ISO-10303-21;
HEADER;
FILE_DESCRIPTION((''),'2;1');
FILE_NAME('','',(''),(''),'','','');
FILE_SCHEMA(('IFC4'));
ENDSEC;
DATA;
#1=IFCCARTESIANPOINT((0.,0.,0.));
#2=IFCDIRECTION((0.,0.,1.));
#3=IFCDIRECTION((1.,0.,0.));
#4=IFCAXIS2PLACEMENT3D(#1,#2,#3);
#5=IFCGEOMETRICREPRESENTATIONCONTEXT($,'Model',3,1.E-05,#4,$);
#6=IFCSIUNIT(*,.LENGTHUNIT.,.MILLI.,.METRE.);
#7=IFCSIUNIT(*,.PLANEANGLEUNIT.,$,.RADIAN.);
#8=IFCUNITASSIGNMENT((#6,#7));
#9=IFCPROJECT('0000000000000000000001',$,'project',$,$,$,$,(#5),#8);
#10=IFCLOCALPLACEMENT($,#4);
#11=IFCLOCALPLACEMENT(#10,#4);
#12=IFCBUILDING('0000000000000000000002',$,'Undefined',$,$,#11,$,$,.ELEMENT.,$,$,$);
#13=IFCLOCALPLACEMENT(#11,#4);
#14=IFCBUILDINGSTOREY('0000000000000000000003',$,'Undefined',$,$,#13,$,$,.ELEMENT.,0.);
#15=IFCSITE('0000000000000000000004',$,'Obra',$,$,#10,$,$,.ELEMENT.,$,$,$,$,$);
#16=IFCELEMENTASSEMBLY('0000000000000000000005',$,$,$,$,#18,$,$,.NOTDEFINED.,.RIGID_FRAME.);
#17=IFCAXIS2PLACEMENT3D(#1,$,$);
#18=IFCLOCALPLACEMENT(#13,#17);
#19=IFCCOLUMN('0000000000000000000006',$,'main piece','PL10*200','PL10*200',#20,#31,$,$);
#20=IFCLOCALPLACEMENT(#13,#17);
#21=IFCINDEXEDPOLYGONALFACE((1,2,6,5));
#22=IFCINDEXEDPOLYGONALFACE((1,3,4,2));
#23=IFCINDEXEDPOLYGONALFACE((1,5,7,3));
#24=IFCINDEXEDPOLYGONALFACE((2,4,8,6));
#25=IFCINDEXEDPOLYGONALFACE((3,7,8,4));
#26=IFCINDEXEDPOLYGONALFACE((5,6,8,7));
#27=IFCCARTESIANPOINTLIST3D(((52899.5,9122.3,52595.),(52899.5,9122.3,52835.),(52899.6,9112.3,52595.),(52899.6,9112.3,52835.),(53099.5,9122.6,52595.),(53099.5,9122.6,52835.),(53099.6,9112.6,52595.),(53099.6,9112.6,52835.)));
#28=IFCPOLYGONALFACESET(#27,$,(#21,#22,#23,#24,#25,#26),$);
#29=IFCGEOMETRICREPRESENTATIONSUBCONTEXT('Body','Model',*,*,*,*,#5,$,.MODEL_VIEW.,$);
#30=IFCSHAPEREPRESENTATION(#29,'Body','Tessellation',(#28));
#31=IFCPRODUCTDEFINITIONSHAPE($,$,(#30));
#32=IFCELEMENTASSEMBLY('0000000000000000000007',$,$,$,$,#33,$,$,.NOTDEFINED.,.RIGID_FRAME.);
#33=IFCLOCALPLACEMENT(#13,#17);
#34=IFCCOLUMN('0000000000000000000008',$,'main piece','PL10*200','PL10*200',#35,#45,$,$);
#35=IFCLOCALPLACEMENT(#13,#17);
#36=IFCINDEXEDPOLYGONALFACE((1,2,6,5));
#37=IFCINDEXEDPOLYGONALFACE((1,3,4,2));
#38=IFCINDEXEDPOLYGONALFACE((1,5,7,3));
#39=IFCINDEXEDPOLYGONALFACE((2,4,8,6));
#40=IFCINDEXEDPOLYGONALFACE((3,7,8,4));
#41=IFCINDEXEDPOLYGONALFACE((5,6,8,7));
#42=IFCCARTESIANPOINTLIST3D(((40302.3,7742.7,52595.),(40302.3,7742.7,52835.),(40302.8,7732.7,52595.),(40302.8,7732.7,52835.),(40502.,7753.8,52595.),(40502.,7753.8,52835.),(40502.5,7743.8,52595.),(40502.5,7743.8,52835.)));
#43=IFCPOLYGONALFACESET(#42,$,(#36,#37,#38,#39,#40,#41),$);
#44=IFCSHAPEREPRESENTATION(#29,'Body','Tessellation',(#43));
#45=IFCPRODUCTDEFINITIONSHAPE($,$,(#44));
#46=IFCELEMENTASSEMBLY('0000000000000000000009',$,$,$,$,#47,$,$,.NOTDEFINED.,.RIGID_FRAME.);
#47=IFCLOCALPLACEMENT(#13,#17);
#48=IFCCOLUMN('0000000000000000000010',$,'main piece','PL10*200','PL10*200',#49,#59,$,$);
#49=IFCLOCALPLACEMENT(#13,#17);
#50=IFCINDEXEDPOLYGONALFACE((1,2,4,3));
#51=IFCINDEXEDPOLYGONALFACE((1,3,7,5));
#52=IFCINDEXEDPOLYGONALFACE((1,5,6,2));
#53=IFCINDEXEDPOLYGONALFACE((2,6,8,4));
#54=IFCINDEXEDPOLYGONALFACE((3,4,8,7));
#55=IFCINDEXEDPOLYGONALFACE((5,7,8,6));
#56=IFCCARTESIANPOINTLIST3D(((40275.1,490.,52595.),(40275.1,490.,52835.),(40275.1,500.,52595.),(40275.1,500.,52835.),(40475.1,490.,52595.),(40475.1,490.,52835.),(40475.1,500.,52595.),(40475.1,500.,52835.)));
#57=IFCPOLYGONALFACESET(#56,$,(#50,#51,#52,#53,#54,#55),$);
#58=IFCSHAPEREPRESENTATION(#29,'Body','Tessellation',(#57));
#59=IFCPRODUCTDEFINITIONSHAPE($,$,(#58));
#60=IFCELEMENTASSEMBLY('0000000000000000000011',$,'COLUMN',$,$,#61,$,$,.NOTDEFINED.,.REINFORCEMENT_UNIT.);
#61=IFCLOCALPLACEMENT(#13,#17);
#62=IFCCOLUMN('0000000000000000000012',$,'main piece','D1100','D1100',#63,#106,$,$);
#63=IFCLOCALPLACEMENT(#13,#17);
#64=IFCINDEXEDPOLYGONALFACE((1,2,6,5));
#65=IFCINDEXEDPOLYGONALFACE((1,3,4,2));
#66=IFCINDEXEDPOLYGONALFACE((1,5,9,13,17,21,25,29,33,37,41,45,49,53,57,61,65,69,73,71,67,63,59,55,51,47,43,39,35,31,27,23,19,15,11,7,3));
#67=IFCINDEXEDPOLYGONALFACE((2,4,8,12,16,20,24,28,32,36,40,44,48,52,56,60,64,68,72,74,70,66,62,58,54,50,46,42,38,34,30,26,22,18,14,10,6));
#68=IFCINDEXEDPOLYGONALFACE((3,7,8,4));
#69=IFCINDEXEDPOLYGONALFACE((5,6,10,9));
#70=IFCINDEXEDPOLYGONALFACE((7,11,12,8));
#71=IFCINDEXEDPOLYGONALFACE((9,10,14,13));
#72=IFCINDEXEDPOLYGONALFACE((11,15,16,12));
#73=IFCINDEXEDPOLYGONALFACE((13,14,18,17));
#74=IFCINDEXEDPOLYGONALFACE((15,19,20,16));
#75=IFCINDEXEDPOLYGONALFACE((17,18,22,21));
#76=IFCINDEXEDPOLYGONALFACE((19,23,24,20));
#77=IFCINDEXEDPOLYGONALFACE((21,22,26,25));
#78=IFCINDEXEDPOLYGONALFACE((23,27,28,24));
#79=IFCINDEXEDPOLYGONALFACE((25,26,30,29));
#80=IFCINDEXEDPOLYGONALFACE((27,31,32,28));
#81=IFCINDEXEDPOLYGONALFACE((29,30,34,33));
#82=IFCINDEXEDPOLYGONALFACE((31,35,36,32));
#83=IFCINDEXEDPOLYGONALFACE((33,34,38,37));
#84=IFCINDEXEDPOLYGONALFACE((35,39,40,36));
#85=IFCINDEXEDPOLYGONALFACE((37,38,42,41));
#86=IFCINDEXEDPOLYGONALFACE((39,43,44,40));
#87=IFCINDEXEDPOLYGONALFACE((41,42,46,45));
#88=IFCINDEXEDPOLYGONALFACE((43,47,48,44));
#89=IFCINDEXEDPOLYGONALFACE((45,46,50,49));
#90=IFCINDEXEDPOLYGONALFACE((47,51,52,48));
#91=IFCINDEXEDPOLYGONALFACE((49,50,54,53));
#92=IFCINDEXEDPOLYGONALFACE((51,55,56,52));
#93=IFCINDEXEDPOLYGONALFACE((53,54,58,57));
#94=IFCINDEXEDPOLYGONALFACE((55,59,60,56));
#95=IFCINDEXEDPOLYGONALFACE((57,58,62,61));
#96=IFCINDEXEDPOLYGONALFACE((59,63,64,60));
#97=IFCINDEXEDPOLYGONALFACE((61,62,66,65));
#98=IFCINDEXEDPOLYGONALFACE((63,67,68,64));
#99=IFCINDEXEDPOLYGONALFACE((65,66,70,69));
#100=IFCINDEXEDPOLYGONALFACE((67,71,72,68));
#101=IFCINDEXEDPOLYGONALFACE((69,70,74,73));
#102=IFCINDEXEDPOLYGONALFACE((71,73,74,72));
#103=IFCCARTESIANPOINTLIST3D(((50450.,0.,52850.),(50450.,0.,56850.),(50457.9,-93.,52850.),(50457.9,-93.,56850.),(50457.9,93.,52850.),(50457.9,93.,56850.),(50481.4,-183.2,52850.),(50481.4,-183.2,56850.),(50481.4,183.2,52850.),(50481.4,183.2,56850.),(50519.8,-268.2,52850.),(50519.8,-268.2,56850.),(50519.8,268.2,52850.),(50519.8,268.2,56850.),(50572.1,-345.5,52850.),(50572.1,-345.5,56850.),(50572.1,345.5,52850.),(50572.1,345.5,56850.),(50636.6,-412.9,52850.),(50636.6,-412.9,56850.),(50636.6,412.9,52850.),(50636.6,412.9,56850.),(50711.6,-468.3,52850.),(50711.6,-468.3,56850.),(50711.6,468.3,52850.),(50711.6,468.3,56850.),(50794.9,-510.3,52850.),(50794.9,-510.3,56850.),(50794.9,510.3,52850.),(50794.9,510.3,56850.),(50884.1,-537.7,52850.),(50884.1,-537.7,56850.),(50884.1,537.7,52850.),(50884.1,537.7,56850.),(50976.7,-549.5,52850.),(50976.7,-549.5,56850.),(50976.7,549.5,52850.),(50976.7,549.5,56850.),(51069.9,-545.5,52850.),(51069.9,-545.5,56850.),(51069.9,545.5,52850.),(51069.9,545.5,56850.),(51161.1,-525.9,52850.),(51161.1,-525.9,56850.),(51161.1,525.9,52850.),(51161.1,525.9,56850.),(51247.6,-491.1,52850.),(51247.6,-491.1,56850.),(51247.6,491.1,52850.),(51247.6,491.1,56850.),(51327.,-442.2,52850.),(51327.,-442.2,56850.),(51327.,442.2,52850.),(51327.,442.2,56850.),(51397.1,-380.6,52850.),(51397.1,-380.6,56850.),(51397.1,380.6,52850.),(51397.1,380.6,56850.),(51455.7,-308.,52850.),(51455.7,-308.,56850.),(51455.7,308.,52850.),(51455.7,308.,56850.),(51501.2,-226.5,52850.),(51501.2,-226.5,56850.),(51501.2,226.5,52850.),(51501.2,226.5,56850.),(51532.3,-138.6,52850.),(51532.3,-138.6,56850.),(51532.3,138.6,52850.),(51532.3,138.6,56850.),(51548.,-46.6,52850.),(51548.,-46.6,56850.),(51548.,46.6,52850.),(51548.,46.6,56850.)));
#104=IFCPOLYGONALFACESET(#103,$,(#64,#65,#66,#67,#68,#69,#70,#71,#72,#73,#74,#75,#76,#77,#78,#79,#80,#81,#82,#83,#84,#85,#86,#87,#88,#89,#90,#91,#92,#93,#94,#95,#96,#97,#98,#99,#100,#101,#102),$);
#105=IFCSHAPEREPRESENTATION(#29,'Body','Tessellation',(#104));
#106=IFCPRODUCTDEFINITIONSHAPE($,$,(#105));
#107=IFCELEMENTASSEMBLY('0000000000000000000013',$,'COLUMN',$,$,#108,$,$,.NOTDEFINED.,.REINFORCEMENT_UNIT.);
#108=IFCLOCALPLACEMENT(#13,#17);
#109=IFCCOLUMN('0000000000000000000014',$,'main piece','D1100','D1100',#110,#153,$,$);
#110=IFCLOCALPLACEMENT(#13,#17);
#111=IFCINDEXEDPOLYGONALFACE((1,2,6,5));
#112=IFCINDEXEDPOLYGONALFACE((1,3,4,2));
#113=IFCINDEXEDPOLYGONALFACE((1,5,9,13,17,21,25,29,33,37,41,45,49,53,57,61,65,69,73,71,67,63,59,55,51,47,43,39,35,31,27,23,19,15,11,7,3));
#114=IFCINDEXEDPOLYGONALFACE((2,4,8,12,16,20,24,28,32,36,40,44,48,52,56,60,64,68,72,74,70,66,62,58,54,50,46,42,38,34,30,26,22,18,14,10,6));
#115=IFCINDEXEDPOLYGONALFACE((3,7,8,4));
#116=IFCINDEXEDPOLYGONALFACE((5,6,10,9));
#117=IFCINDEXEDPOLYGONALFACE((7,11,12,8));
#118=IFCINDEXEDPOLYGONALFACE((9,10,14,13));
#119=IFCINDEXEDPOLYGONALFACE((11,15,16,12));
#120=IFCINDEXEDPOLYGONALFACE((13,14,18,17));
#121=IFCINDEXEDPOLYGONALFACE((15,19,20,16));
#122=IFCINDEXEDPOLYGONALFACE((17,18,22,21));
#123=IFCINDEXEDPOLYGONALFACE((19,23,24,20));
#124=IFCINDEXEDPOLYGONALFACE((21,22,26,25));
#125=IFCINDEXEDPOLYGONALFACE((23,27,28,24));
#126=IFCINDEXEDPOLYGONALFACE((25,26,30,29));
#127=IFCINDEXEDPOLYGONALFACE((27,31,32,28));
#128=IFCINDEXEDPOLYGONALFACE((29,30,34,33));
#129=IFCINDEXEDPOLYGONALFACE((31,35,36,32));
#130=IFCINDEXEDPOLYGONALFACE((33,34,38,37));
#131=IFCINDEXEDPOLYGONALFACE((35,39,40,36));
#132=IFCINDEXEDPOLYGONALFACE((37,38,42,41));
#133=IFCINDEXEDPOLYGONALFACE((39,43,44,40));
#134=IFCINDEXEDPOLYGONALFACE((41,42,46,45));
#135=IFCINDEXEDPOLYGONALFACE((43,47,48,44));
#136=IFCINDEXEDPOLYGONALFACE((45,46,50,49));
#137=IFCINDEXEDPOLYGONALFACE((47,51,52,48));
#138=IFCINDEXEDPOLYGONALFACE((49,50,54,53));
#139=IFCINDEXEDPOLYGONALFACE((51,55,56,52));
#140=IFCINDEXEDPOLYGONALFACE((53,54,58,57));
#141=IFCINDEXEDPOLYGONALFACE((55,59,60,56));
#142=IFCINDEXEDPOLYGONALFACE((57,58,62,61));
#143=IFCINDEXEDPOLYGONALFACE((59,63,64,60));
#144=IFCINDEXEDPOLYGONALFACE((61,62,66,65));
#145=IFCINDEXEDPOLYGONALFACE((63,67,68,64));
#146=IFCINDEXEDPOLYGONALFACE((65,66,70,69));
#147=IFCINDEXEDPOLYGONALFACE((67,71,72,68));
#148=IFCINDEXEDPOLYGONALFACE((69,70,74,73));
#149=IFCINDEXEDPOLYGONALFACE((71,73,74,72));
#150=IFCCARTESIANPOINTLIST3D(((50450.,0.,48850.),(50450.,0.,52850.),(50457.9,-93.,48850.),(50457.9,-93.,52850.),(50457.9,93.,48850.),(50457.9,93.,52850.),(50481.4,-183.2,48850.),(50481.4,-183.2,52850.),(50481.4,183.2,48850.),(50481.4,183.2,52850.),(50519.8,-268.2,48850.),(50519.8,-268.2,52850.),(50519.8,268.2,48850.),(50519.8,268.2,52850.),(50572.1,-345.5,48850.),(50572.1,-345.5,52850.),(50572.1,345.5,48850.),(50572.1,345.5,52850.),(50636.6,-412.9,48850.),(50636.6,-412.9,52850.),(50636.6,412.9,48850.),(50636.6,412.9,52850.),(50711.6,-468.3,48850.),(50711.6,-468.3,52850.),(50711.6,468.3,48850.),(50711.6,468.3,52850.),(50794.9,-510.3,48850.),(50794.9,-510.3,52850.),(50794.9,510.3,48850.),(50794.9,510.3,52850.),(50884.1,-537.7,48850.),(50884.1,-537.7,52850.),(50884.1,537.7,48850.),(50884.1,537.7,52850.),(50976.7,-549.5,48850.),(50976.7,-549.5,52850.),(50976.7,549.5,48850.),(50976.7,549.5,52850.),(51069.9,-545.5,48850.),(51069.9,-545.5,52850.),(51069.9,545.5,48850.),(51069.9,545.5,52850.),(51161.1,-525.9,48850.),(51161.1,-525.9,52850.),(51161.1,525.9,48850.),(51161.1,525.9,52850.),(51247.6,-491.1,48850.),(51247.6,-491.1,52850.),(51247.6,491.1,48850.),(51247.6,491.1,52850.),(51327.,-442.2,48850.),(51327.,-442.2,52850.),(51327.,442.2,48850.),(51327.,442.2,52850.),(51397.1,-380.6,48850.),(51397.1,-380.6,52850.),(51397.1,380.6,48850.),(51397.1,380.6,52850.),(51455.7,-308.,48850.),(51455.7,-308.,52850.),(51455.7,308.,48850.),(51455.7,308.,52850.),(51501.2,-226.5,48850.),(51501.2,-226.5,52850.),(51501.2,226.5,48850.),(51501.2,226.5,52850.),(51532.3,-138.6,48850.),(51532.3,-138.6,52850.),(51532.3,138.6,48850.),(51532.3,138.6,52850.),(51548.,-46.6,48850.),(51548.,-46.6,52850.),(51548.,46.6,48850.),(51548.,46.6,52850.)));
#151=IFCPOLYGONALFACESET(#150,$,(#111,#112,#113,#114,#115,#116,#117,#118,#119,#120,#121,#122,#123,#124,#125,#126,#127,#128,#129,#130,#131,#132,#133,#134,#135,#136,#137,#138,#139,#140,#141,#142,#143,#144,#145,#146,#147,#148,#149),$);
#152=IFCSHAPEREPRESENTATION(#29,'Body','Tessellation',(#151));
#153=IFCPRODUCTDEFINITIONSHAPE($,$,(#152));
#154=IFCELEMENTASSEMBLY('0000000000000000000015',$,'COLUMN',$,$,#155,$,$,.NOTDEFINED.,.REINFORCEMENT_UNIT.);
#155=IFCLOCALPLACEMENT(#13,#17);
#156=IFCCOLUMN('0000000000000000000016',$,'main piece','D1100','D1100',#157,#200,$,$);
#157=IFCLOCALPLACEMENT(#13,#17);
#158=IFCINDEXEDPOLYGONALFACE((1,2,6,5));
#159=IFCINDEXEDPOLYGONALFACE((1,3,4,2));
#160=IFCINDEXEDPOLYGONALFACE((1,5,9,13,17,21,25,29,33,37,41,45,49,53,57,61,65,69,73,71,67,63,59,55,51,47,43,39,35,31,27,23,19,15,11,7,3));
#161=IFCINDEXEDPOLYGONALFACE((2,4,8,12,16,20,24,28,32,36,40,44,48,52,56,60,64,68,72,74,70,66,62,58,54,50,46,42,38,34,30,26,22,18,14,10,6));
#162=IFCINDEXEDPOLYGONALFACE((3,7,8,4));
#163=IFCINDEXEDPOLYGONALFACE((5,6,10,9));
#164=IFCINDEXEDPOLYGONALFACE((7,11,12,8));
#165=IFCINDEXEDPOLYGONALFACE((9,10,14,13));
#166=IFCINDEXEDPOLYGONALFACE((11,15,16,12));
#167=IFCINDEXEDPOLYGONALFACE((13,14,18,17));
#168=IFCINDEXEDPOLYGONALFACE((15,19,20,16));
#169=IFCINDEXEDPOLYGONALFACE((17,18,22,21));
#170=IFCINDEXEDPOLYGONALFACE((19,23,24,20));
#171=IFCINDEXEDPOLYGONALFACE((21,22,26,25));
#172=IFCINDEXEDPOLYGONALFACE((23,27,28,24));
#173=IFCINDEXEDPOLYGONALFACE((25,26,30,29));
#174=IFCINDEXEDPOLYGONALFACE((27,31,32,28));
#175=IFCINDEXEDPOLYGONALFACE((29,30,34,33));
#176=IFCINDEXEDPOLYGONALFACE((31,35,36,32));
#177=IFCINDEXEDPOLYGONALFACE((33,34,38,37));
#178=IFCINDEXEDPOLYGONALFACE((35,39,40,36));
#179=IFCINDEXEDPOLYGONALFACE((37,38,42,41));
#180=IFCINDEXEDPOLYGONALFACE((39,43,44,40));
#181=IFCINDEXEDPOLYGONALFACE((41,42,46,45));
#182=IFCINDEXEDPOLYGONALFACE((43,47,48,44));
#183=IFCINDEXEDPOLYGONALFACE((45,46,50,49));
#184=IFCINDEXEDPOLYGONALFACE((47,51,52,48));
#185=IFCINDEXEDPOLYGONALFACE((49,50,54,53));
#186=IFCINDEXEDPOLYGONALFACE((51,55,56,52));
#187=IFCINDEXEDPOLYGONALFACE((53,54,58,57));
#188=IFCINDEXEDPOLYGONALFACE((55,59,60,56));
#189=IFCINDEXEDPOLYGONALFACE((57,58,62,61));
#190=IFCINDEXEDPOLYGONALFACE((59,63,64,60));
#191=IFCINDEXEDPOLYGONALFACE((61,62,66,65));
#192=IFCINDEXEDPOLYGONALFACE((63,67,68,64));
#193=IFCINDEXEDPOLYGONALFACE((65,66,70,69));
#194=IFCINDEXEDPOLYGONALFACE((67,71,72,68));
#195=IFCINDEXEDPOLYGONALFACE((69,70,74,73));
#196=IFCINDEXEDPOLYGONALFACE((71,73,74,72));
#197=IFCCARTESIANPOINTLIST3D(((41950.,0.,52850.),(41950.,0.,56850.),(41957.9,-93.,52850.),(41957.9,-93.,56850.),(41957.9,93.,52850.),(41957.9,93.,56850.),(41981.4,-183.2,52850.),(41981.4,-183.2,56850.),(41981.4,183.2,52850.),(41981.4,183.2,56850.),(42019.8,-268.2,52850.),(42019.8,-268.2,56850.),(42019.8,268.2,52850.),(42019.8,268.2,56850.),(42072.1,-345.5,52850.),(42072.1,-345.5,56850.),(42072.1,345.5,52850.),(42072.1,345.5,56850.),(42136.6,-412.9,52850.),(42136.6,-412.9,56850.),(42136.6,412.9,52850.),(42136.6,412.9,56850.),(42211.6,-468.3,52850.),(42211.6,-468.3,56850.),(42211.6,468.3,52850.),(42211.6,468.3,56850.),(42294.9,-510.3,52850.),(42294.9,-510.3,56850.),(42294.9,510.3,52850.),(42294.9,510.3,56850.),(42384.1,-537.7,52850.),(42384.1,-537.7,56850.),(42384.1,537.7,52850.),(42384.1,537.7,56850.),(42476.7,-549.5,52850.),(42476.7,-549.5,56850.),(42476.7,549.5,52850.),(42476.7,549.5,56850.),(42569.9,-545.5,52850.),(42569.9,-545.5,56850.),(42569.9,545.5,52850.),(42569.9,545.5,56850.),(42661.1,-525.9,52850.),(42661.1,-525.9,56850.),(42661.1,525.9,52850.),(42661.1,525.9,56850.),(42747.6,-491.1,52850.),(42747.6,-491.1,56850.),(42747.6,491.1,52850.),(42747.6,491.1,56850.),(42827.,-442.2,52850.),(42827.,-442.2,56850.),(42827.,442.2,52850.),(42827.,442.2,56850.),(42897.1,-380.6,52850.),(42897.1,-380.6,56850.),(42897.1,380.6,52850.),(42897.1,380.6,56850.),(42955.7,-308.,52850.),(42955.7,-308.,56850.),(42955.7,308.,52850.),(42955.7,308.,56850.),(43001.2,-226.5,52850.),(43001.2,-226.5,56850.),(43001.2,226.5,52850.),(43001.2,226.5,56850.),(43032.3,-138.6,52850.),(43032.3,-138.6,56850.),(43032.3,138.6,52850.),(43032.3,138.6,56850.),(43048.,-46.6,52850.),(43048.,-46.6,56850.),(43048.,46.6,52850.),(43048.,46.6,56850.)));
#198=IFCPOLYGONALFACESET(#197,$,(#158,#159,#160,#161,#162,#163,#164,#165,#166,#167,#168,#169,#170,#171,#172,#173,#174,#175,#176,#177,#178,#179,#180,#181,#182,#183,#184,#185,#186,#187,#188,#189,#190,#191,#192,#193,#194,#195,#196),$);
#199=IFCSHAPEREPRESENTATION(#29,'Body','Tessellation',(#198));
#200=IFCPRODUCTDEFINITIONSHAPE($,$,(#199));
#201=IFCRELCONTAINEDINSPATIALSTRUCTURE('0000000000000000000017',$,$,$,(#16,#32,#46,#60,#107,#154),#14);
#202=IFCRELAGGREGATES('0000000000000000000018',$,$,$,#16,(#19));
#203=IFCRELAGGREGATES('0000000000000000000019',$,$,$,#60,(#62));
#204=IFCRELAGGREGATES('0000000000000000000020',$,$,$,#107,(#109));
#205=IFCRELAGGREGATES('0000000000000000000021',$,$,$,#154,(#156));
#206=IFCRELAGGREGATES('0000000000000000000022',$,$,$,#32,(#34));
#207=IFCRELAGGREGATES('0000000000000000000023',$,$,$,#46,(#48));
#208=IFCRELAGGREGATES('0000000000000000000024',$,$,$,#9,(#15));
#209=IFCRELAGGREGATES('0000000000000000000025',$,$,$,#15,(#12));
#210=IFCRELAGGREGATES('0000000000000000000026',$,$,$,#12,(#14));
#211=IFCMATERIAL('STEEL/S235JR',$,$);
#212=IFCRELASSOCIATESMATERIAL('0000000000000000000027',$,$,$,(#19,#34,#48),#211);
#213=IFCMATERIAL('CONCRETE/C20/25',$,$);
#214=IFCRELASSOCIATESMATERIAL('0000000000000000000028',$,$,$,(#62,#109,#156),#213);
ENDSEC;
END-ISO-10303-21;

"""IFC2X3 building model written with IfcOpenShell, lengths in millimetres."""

from ifc_helpers import new_model, si_unit, frame, origin_with_axes, origin_2d_with_axis, place, context, subcontext, project, spatial, rectangle, circle, extrude, material, element, aggregate, save


model = new_model("IFC2X3")

# Units and contexts
model_context = context("Model", 3, precision=1e-05, world=origin_with_axes())
body_context = subcontext(model_context, "Body", "Model", "MODEL_VIEW")
ifc_project = project(units=[si_unit("LENGTHUNIT", "METRE", prefix="MILLI"), si_unit("PLANEANGLEUNIT", "RADIAN")], contexts=[model_context])

# Site, building, storey
site_placement = place(None, origin_with_axes())
site = spatial("IfcSite", under=ifc_project, at=site_placement, Name="Obra", CompositionType="ELEMENT")
building_placement = place(site_placement, origin_with_axes())
building = spatial("IfcBuilding", under=site, at=building_placement, Name="Undefined", CompositionType="ELEMENT")
storey_placement = place(building_placement, origin_with_axes())
storey = spatial("IfcBuildingStorey", under=building, at=storey_placement, Name="Undefined", CompositionType="ELEMENT", Elevation=0.0)

# Element assemblies, columns
assembly_1_placement = place(storey_placement, origin_with_axes())
assembly_1 = element("IfcElementAssembly", 1, at=assembly_1_placement, inside=storey, AssemblyPlace="NOTDEFINED", PredefinedType="RIGID_FRAME")
ifc_material_1 = material(Name="STEEL/S235JR")
column_1_placement = place(assembly_1_placement, frame((52999.6, 9117.5, 52595.0), z_axis=(0.0, 0.0, 1.0), x_axis=(0.999999, 0.001508, 0.0)))
column_1 = element("IfcColumn", 2, at=column_1_placement, material=ifc_material_1, Name="main piece", Description="PL10*200", ObjectType="PL10*200", context=body_context, shape_type="SweptSolid", body=[
    extrude(rectangle(XDim=10.0, YDim=200.0, at=origin_2d_with_axis()), frame((0.0, 0.0, 240.0), z_axis=(0.0, 0.0, -1.0), x_axis=(0.0, 1.0, 0.0)), (0.0, 0.0, 1.0), 240.0),
])
aggregate(assembly_1, [column_1])
assembly_2_placement = place(storey_placement, origin_with_axes())
assembly_2 = element("IfcElementAssembly", 3, at=assembly_2_placement, inside=storey, AssemblyPlace="NOTDEFINED", PredefinedType="RIGID_FRAME")
column_2_placement = place(assembly_2_placement, frame((40402.4, 7743.3, 52595.0), z_axis=(0.0, 0.0, 1.0), x_axis=(-0.998478, -0.055152, 0.0)))
column_2 = element("IfcColumn", 4, at=column_2_placement, material=ifc_material_1, Name="main piece", Description="PL10*200", ObjectType="PL10*200", context=body_context, shape_type="SweptSolid", body=[
    extrude(rectangle(XDim=10.0, YDim=200.0, at=origin_2d_with_axis()), frame((0.0, 0.0, 240.0), z_axis=(0.0, 0.0, -1.0), x_axis=(0.0, 1.0, 0.0)), (0.0, 0.0, 1.0), 240.0),
])
assembly_3_placement = place(storey_placement, origin_with_axes())
assembly_3 = element("IfcElementAssembly", 5, at=assembly_3_placement, inside=storey, AssemblyPlace="NOTDEFINED", PredefinedType="RIGID_FRAME")
column_3_placement = place(assembly_3_placement, frame((40375.1, 495.0, 52595.0), z_axis=(0.0, 0.0, 1.0), x_axis=(1.0, 0.000002, 0.0)))
column_3 = element("IfcColumn", 6, at=column_3_placement, material=ifc_material_1, Name="main piece", Description="PL10*200", ObjectType="PL10*200", context=body_context, shape_type="SweptSolid", body=[
    extrude(rectangle(XDim=10.0, YDim=200.0, at=origin_2d_with_axis()), frame((0.0, 0.0, 240.0), z_axis=(0.0, 0.0, -1.0), x_axis=(0.0, 1.0, 0.0)), (0.0, 0.0, 1.0), 240.0),
])
assembly_4_placement = place(storey_placement, origin_with_axes())
assembly_4 = element("IfcElementAssembly", 7, at=assembly_4_placement, inside=storey, Name="COLUMN", AssemblyPlace="NOTDEFINED", PredefinedType="REINFORCEMENT_UNIT")
ifc_material_2 = material(Name="CONCRETE/C20/25")
column_4_placement = place(assembly_4_placement, frame((51000.0, 0.0, 52850.0), z_axis=(0.0, 0.0, 1.0), x_axis=(0.0, 1.0, 0.0)))
column_4 = element("IfcColumn", 8, at=column_4_placement, material=ifc_material_2, Name="main piece", Description="D1100", ObjectType="D1100", context=body_context, shape_type="SweptSolid", body=[
    extrude(circle(Radius=550.0, at=origin_2d_with_axis()), frame((0.0, 0.0, 4000.0), z_axis=(0.0, 0.0, -1.0), x_axis=(0.0, 1.0, 0.0)), (0.0, 0.0, 1.0), 4000.0),
])
aggregate(assembly_4, [column_4])
assembly_5_placement = place(storey_placement, origin_with_axes())
assembly_5 = element("IfcElementAssembly", 9, at=assembly_5_placement, inside=storey, Name="COLUMN", AssemblyPlace="NOTDEFINED", PredefinedType="REINFORCEMENT_UNIT")
column_5_placement = place(assembly_5_placement, frame((51000.0, 0.0, 48850.0), z_axis=(0.0, 0.0, 1.0), x_axis=(0.0, 1.0, 0.0)))
column_5 = element("IfcColumn", 10, at=column_5_placement, material=ifc_material_2, Name="main piece", Description="D1100", ObjectType="D1100", context=body_context, shape_type="SweptSolid", body=[
    extrude(circle(Radius=550.0, at=origin_2d_with_axis()), frame((0.0, 0.0, 4000.0), z_axis=(0.0, 0.0, -1.0), x_axis=(0.0, 1.0, 0.0)), (0.0, 0.0, 1.0), 4000.0),
])
aggregate(assembly_5, [column_5])
assembly_6_placement = place(storey_placement, origin_with_axes())
assembly_6 = element("IfcElementAssembly", 11, at=assembly_6_placement, inside=storey, Name="COLUMN", AssemblyPlace="NOTDEFINED", PredefinedType="REINFORCEMENT_UNIT")
column_6_placement = place(assembly_6_placement, frame((42500.0, 0.0, 52850.0), z_axis=(0.0, 0.0, 1.0), x_axis=(0.0, 1.0, 0.0)))
column_6 = element("IfcColumn", 12, at=column_6_placement, material=ifc_material_2, Name="main piece", Description="D1100", ObjectType="D1100", context=body_context, shape_type="SweptSolid", body=[
    extrude(circle(Radius=550.0, at=origin_2d_with_axis()), frame((0.0, 0.0, 4000.0), z_axis=(0.0, 0.0, -1.0), x_axis=(0.0, 1.0, 0.0)), (0.0, 0.0, 1.0), 4000.0),
])
aggregate(assembly_6, [column_6])

aggregate(assembly_2, [column_2])
aggregate(assembly_3, [column_3])

save(model, "model.ifc")
